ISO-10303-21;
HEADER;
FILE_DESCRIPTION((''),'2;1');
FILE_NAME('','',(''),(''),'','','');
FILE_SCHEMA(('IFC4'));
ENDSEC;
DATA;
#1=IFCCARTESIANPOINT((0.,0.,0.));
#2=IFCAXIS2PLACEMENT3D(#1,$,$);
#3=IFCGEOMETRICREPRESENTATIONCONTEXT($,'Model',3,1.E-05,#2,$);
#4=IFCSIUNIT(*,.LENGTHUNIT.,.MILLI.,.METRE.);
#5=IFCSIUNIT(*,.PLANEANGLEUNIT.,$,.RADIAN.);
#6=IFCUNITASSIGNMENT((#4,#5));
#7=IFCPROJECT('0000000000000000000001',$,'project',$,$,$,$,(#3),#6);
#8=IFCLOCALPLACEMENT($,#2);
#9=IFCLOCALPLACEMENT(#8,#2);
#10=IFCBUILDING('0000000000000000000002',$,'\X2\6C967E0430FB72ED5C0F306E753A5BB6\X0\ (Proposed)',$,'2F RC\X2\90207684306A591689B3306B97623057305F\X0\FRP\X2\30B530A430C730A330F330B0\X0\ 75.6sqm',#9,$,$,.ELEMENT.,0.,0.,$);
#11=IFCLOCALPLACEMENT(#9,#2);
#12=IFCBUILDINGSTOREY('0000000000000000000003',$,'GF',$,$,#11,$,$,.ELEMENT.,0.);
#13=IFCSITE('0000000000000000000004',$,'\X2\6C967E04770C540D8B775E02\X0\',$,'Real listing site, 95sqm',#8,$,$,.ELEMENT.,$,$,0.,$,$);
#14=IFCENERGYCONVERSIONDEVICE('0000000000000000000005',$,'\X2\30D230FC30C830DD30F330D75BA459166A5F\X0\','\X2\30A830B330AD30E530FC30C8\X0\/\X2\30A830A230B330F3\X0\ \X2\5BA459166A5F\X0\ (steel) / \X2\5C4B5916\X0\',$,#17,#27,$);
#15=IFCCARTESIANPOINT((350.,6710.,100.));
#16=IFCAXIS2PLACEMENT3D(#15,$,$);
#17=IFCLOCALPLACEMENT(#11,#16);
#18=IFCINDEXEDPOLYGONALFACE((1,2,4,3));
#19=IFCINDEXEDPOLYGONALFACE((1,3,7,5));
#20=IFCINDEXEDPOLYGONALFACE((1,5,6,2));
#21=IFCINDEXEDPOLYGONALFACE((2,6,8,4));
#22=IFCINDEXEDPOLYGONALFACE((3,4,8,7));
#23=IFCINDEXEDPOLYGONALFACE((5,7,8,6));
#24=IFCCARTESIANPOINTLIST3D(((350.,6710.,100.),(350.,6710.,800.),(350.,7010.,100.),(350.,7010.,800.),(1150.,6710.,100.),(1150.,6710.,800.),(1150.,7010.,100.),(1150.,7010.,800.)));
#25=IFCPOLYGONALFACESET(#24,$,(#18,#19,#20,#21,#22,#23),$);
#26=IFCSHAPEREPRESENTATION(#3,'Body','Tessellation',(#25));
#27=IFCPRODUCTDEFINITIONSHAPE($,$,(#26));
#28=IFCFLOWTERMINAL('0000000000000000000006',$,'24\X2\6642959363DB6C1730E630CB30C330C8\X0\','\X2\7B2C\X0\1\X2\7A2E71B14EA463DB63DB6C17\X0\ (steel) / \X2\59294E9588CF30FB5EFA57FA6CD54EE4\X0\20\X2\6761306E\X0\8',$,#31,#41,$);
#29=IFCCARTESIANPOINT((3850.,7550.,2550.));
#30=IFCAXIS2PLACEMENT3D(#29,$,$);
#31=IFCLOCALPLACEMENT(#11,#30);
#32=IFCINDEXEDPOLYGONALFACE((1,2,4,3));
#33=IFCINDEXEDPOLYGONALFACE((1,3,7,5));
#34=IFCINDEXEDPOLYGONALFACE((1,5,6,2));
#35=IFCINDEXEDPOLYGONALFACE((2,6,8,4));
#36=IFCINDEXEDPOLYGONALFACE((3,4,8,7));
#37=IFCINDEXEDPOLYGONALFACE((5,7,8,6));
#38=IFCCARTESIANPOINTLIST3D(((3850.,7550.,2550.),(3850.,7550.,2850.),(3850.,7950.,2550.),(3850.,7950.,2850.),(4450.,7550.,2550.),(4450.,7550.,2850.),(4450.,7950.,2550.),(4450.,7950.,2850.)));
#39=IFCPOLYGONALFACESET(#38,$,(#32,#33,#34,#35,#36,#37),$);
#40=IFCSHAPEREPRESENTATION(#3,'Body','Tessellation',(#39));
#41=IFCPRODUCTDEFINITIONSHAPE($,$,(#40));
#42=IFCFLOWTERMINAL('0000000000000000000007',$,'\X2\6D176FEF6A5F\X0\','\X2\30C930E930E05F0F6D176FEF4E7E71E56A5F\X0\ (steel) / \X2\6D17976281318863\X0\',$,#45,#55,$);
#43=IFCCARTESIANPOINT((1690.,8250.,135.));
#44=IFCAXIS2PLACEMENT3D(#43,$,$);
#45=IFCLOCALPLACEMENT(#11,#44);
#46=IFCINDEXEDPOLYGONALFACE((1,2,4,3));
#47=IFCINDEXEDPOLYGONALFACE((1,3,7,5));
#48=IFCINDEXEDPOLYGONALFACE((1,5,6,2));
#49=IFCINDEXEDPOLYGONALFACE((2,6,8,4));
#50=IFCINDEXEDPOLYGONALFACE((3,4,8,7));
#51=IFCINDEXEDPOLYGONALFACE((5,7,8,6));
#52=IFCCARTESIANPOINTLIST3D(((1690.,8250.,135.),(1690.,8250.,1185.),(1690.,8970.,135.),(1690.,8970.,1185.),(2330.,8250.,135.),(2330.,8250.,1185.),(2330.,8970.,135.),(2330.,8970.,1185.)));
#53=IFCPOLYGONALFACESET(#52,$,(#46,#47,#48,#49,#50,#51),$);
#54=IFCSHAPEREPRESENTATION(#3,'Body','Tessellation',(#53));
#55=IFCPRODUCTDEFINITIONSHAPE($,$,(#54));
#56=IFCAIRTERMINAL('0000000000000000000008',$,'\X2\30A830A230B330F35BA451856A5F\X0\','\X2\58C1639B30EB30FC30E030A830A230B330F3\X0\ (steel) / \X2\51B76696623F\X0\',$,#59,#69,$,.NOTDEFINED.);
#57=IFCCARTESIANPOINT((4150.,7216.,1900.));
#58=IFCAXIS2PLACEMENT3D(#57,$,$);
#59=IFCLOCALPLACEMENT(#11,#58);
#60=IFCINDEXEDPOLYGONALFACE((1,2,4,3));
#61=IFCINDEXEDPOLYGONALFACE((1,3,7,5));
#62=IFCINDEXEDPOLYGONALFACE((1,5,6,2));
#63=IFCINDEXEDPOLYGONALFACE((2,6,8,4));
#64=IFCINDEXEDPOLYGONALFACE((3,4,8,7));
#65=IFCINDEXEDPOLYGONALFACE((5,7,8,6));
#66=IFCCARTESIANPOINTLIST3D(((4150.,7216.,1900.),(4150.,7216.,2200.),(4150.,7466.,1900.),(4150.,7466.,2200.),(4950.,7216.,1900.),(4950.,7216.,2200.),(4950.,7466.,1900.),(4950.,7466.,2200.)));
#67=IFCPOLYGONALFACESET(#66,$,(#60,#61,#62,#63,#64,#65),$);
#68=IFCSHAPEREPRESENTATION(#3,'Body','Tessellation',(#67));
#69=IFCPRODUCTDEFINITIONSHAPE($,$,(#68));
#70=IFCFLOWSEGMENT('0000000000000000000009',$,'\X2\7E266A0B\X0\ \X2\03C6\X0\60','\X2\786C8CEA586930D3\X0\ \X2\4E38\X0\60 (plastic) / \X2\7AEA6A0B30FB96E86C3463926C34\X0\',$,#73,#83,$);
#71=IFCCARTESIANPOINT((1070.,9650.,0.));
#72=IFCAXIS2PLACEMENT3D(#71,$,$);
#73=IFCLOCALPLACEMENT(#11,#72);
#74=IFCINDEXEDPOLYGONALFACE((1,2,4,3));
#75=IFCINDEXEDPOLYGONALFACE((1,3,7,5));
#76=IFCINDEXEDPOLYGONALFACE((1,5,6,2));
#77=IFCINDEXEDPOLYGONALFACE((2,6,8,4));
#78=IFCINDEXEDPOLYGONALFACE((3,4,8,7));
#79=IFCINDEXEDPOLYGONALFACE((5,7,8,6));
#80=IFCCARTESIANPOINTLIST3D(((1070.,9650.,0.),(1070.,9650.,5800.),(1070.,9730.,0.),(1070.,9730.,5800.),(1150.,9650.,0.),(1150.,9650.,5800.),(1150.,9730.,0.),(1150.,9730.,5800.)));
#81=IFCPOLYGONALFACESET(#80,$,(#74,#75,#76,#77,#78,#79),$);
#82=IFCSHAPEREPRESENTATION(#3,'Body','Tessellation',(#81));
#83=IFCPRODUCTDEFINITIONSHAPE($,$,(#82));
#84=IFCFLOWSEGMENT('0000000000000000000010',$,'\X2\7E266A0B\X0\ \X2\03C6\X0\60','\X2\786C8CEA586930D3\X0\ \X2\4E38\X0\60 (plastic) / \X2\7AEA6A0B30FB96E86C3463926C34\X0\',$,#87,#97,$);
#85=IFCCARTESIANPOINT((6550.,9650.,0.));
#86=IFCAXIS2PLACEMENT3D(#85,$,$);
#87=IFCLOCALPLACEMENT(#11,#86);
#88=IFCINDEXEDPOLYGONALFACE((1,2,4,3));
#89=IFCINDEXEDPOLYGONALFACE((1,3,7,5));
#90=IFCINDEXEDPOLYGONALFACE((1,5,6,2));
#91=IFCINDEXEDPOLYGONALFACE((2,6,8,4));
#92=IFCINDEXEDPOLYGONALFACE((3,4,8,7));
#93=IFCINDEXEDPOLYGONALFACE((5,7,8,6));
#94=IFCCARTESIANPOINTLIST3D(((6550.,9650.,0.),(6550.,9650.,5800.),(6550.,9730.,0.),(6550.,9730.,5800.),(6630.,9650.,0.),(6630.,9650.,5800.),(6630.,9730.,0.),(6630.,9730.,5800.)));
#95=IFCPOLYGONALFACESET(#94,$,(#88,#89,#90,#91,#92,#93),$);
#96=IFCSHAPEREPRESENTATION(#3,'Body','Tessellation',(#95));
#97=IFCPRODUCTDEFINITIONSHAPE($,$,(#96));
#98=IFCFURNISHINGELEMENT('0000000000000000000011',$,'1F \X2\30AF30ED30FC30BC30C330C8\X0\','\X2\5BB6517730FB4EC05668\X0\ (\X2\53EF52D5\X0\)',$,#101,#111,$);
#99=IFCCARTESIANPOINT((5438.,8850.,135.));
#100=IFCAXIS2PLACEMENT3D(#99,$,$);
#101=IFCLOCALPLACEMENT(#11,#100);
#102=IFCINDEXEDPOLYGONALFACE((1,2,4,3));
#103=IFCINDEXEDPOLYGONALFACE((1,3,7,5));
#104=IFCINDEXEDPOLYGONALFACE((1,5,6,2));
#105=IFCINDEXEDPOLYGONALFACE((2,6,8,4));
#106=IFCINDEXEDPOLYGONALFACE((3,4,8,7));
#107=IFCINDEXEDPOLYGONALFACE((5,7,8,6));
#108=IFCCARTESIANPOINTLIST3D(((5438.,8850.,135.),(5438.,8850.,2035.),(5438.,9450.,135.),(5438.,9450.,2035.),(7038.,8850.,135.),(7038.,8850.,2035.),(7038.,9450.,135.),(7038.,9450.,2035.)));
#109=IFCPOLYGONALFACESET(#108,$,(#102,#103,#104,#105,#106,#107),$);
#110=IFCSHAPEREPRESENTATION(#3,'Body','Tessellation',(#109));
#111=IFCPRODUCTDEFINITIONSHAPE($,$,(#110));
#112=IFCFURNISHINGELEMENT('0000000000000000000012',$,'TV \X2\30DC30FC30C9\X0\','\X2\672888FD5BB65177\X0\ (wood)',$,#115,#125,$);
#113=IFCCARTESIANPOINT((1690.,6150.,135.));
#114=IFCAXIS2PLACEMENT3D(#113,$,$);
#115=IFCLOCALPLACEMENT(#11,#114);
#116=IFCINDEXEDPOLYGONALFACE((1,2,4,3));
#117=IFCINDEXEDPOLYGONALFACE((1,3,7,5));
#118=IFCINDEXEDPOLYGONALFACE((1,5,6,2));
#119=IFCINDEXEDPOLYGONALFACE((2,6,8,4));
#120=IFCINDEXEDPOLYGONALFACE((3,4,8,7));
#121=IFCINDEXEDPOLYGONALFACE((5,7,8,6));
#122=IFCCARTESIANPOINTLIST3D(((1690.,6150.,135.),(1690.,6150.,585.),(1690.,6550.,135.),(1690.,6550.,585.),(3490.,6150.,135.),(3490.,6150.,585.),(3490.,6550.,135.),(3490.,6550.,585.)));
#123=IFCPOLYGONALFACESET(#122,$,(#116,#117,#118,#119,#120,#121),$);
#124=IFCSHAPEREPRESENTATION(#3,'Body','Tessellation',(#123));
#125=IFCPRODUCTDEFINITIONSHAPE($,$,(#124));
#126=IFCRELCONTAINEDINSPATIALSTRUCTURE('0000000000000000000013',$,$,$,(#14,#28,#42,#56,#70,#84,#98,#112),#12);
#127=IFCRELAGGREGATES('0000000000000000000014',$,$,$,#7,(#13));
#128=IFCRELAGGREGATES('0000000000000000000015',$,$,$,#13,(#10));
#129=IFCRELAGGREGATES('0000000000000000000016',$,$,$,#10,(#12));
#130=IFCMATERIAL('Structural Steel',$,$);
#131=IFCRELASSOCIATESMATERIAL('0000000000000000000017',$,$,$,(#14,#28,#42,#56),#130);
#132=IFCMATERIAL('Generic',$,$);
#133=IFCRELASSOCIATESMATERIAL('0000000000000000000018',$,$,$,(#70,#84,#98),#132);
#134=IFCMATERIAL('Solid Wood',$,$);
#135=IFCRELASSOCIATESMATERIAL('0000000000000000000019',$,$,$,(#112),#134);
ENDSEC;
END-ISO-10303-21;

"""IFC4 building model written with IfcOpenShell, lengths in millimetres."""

from ifc_helpers import new_model, si_unit, frame, frame_2d, origin, place, context, project, spatial, rectangle, extrude, material, element, save


model = new_model("IFC4")

# Units and contexts
model_context = context("Model", 3, precision=1e-05, world=origin())
ifc_project = project(units=[si_unit("LENGTHUNIT", "METRE", prefix="MILLI"), si_unit("PLANEANGLEUNIT", "RADIAN")], contexts=[model_context])

# Site, building, storey
site_placement = place(None, origin())
site = spatial("IfcSite", under=ifc_project, at=site_placement, Name="沖縄県名護市", ObjectType="Real listing site, 95sqm", CompositionType="ELEMENT", RefElevation=0.0)
building_placement = place(site_placement, origin())
building = spatial("IfcBuilding", under=site, at=building_placement, Name="沖縄・狭小の町家 (Proposed)", ObjectType="2F RC造的な外観に面したFRPサイディング 75.6sqm", CompositionType="ELEMENT", ElevationOfRefHeight=0.0, ElevationOfTerrain=0.0)
storey_placement = place(building_placement, origin())
storey = spatial("IfcBuildingStorey", under=building, at=storey_placement, Name="GF", CompositionType="ELEMENT", Elevation=0.0)

# Shared definitions
ifc_material_1 = material(Name="Solid Wood")

# Shared definitions
ifc_material_2 = material(Name="Generic")

# Shared definitions
ifc_material_3 = material(Name="Structural Steel")

# Energy conversion device
energy_conversion_device_placement = place(storey_placement, frame((350.0, 6710.0, 100.0)))
element("IfcEnergyConversionDevice", 1, at=energy_conversion_device_placement, inside=storey, material=ifc_material_3, Name="ヒートポンプ室外機", Description="エコキュート/エアコン 室外機 (steel) / 屋外", context=model_context, shape_type="SweptSolid", body=[
    extrude(rectangle(XDim=800.0, YDim=300.0, at=frame_2d((400.0, 150.0))), frame((350.0, 6710.0, 100.0)), (0.0, 0.0, 1.0), 700.0),
])

# Flow terminals
flow_terminal_1_placement = place(storey_placement, frame((3850.0, 7550.0, 2550.0)))
element("IfcFlowTerminal", 2, at=flow_terminal_1_placement, inside=storey, material=ifc_material_3, Name="24時間換気ユニット", Description="第1種熱交換換気 (steel) / 天井裏・建基法令20条の8", context=model_context, shape_type="SweptSolid", body=[
    extrude(rectangle(XDim=600.0, YDim=400.0, at=frame_2d((300.0, 200.0))), frame((3850.0, 7550.0, 2550.0)), (0.0, 0.0, 1.0), 300.0),
])
flow_terminal_2_placement = place(storey_placement, frame((1690.0, 8250.0, 135.0)))
element("IfcFlowTerminal", 3, at=flow_terminal_2_placement, inside=storey, material=ifc_material_3, Name="洗濯機", Description="ドラム式洗濯乾燥機 (steel) / 洗面脱衣", context=model_context, shape_type="SweptSolid", body=[
    extrude(rectangle(XDim=640.0, YDim=720.0, at=frame_2d((320.0, 360.0))), frame((1690.0, 8250.0, 135.0)), (0.0, 0.0, 1.0), 1050.0),
])

# Air terminal
air_terminal_placement = place(storey_placement, frame((4150.0, 7216.0, 1900.0)))
element("IfcAirTerminal", 4, at=air_terminal_placement, inside=storey, material=ifc_material_3, Name="エアコン室内機", Description="壁掛ルームエアコン (steel) / 冷暖房", PredefinedType="NOTDEFINED", context=model_context, shape_type="SweptSolid", body=[
    extrude(rectangle(XDim=800.0, YDim=250.0, at=frame_2d((400.0, 125.0))), frame((4150.0, 7216.0, 1900.0)), (0.0, 0.0, 1.0), 300.0),
])

# Flow segments
flow_segment_1_placement = place(storey_placement, frame((1070.0, 9650.0, 0.0)))
element("IfcFlowSegment", 5, at=flow_segment_1_placement, inside=storey, material=ifc_material_2, Name="縦樋 φ60", Description="硬質塩ビ 丸60 (plastic) / 竪樋・雨水排水", context=model_context, shape_type="SweptSolid", body=[
    extrude(rectangle(XDim=80.0, YDim=80.0, at=frame_2d((40.0, 40.0))), frame((1070.0, 9650.0, 0.0)), (0.0, 0.0, 1.0), 5800.0),
])
flow_segment_2_placement = place(storey_placement, frame((6550.0, 9650.0, 0.0)))
element("IfcFlowSegment", 6, at=flow_segment_2_placement, inside=storey, material=ifc_material_2, Name="縦樋 φ60", Description="硬質塩ビ 丸60 (plastic) / 竪樋・雨水排水", context=model_context, shape_type="SweptSolid", body=[
    extrude(rectangle(XDim=80.0, YDim=80.0, at=frame_2d((40.0, 40.0))), frame((6550.0, 9650.0, 0.0)), (0.0, 0.0, 1.0), 5800.0),
])

# Furnishing elements
furnishing_1_placement = place(storey_placement, frame((5438.0, 8850.0, 135.0)))
element("IfcFurnishingElement", 7, at=furnishing_1_placement, inside=storey, material=ifc_material_2, Name="1F クローゼット", Description="家具・什器 (可動)", context=model_context, shape_type="SweptSolid", body=[
    extrude(rectangle(XDim=1600.0, YDim=600.0, at=frame_2d((800.0, 300.0))), frame((5438.0, 8850.0, 135.0)), (0.0, 0.0, 1.0), 1900.0),
])
furnishing_2_placement = place(storey_placement, frame((1690.0, 6150.0, 135.0)))
element("IfcFurnishingElement", 8, at=furnishing_2_placement, inside=storey, material=ifc_material_1, Name="TV ボード", Description="木製家具 (wood)", context=model_context, shape_type="SweptSolid", body=[
    extrude(rectangle(XDim=1800.0, YDim=400.0, at=frame_2d((900.0, 200.0))), frame((1690.0, 6150.0, 135.0)), (0.0, 0.0, 1.0), 450.0),
])

save(model, "model.ifc")
